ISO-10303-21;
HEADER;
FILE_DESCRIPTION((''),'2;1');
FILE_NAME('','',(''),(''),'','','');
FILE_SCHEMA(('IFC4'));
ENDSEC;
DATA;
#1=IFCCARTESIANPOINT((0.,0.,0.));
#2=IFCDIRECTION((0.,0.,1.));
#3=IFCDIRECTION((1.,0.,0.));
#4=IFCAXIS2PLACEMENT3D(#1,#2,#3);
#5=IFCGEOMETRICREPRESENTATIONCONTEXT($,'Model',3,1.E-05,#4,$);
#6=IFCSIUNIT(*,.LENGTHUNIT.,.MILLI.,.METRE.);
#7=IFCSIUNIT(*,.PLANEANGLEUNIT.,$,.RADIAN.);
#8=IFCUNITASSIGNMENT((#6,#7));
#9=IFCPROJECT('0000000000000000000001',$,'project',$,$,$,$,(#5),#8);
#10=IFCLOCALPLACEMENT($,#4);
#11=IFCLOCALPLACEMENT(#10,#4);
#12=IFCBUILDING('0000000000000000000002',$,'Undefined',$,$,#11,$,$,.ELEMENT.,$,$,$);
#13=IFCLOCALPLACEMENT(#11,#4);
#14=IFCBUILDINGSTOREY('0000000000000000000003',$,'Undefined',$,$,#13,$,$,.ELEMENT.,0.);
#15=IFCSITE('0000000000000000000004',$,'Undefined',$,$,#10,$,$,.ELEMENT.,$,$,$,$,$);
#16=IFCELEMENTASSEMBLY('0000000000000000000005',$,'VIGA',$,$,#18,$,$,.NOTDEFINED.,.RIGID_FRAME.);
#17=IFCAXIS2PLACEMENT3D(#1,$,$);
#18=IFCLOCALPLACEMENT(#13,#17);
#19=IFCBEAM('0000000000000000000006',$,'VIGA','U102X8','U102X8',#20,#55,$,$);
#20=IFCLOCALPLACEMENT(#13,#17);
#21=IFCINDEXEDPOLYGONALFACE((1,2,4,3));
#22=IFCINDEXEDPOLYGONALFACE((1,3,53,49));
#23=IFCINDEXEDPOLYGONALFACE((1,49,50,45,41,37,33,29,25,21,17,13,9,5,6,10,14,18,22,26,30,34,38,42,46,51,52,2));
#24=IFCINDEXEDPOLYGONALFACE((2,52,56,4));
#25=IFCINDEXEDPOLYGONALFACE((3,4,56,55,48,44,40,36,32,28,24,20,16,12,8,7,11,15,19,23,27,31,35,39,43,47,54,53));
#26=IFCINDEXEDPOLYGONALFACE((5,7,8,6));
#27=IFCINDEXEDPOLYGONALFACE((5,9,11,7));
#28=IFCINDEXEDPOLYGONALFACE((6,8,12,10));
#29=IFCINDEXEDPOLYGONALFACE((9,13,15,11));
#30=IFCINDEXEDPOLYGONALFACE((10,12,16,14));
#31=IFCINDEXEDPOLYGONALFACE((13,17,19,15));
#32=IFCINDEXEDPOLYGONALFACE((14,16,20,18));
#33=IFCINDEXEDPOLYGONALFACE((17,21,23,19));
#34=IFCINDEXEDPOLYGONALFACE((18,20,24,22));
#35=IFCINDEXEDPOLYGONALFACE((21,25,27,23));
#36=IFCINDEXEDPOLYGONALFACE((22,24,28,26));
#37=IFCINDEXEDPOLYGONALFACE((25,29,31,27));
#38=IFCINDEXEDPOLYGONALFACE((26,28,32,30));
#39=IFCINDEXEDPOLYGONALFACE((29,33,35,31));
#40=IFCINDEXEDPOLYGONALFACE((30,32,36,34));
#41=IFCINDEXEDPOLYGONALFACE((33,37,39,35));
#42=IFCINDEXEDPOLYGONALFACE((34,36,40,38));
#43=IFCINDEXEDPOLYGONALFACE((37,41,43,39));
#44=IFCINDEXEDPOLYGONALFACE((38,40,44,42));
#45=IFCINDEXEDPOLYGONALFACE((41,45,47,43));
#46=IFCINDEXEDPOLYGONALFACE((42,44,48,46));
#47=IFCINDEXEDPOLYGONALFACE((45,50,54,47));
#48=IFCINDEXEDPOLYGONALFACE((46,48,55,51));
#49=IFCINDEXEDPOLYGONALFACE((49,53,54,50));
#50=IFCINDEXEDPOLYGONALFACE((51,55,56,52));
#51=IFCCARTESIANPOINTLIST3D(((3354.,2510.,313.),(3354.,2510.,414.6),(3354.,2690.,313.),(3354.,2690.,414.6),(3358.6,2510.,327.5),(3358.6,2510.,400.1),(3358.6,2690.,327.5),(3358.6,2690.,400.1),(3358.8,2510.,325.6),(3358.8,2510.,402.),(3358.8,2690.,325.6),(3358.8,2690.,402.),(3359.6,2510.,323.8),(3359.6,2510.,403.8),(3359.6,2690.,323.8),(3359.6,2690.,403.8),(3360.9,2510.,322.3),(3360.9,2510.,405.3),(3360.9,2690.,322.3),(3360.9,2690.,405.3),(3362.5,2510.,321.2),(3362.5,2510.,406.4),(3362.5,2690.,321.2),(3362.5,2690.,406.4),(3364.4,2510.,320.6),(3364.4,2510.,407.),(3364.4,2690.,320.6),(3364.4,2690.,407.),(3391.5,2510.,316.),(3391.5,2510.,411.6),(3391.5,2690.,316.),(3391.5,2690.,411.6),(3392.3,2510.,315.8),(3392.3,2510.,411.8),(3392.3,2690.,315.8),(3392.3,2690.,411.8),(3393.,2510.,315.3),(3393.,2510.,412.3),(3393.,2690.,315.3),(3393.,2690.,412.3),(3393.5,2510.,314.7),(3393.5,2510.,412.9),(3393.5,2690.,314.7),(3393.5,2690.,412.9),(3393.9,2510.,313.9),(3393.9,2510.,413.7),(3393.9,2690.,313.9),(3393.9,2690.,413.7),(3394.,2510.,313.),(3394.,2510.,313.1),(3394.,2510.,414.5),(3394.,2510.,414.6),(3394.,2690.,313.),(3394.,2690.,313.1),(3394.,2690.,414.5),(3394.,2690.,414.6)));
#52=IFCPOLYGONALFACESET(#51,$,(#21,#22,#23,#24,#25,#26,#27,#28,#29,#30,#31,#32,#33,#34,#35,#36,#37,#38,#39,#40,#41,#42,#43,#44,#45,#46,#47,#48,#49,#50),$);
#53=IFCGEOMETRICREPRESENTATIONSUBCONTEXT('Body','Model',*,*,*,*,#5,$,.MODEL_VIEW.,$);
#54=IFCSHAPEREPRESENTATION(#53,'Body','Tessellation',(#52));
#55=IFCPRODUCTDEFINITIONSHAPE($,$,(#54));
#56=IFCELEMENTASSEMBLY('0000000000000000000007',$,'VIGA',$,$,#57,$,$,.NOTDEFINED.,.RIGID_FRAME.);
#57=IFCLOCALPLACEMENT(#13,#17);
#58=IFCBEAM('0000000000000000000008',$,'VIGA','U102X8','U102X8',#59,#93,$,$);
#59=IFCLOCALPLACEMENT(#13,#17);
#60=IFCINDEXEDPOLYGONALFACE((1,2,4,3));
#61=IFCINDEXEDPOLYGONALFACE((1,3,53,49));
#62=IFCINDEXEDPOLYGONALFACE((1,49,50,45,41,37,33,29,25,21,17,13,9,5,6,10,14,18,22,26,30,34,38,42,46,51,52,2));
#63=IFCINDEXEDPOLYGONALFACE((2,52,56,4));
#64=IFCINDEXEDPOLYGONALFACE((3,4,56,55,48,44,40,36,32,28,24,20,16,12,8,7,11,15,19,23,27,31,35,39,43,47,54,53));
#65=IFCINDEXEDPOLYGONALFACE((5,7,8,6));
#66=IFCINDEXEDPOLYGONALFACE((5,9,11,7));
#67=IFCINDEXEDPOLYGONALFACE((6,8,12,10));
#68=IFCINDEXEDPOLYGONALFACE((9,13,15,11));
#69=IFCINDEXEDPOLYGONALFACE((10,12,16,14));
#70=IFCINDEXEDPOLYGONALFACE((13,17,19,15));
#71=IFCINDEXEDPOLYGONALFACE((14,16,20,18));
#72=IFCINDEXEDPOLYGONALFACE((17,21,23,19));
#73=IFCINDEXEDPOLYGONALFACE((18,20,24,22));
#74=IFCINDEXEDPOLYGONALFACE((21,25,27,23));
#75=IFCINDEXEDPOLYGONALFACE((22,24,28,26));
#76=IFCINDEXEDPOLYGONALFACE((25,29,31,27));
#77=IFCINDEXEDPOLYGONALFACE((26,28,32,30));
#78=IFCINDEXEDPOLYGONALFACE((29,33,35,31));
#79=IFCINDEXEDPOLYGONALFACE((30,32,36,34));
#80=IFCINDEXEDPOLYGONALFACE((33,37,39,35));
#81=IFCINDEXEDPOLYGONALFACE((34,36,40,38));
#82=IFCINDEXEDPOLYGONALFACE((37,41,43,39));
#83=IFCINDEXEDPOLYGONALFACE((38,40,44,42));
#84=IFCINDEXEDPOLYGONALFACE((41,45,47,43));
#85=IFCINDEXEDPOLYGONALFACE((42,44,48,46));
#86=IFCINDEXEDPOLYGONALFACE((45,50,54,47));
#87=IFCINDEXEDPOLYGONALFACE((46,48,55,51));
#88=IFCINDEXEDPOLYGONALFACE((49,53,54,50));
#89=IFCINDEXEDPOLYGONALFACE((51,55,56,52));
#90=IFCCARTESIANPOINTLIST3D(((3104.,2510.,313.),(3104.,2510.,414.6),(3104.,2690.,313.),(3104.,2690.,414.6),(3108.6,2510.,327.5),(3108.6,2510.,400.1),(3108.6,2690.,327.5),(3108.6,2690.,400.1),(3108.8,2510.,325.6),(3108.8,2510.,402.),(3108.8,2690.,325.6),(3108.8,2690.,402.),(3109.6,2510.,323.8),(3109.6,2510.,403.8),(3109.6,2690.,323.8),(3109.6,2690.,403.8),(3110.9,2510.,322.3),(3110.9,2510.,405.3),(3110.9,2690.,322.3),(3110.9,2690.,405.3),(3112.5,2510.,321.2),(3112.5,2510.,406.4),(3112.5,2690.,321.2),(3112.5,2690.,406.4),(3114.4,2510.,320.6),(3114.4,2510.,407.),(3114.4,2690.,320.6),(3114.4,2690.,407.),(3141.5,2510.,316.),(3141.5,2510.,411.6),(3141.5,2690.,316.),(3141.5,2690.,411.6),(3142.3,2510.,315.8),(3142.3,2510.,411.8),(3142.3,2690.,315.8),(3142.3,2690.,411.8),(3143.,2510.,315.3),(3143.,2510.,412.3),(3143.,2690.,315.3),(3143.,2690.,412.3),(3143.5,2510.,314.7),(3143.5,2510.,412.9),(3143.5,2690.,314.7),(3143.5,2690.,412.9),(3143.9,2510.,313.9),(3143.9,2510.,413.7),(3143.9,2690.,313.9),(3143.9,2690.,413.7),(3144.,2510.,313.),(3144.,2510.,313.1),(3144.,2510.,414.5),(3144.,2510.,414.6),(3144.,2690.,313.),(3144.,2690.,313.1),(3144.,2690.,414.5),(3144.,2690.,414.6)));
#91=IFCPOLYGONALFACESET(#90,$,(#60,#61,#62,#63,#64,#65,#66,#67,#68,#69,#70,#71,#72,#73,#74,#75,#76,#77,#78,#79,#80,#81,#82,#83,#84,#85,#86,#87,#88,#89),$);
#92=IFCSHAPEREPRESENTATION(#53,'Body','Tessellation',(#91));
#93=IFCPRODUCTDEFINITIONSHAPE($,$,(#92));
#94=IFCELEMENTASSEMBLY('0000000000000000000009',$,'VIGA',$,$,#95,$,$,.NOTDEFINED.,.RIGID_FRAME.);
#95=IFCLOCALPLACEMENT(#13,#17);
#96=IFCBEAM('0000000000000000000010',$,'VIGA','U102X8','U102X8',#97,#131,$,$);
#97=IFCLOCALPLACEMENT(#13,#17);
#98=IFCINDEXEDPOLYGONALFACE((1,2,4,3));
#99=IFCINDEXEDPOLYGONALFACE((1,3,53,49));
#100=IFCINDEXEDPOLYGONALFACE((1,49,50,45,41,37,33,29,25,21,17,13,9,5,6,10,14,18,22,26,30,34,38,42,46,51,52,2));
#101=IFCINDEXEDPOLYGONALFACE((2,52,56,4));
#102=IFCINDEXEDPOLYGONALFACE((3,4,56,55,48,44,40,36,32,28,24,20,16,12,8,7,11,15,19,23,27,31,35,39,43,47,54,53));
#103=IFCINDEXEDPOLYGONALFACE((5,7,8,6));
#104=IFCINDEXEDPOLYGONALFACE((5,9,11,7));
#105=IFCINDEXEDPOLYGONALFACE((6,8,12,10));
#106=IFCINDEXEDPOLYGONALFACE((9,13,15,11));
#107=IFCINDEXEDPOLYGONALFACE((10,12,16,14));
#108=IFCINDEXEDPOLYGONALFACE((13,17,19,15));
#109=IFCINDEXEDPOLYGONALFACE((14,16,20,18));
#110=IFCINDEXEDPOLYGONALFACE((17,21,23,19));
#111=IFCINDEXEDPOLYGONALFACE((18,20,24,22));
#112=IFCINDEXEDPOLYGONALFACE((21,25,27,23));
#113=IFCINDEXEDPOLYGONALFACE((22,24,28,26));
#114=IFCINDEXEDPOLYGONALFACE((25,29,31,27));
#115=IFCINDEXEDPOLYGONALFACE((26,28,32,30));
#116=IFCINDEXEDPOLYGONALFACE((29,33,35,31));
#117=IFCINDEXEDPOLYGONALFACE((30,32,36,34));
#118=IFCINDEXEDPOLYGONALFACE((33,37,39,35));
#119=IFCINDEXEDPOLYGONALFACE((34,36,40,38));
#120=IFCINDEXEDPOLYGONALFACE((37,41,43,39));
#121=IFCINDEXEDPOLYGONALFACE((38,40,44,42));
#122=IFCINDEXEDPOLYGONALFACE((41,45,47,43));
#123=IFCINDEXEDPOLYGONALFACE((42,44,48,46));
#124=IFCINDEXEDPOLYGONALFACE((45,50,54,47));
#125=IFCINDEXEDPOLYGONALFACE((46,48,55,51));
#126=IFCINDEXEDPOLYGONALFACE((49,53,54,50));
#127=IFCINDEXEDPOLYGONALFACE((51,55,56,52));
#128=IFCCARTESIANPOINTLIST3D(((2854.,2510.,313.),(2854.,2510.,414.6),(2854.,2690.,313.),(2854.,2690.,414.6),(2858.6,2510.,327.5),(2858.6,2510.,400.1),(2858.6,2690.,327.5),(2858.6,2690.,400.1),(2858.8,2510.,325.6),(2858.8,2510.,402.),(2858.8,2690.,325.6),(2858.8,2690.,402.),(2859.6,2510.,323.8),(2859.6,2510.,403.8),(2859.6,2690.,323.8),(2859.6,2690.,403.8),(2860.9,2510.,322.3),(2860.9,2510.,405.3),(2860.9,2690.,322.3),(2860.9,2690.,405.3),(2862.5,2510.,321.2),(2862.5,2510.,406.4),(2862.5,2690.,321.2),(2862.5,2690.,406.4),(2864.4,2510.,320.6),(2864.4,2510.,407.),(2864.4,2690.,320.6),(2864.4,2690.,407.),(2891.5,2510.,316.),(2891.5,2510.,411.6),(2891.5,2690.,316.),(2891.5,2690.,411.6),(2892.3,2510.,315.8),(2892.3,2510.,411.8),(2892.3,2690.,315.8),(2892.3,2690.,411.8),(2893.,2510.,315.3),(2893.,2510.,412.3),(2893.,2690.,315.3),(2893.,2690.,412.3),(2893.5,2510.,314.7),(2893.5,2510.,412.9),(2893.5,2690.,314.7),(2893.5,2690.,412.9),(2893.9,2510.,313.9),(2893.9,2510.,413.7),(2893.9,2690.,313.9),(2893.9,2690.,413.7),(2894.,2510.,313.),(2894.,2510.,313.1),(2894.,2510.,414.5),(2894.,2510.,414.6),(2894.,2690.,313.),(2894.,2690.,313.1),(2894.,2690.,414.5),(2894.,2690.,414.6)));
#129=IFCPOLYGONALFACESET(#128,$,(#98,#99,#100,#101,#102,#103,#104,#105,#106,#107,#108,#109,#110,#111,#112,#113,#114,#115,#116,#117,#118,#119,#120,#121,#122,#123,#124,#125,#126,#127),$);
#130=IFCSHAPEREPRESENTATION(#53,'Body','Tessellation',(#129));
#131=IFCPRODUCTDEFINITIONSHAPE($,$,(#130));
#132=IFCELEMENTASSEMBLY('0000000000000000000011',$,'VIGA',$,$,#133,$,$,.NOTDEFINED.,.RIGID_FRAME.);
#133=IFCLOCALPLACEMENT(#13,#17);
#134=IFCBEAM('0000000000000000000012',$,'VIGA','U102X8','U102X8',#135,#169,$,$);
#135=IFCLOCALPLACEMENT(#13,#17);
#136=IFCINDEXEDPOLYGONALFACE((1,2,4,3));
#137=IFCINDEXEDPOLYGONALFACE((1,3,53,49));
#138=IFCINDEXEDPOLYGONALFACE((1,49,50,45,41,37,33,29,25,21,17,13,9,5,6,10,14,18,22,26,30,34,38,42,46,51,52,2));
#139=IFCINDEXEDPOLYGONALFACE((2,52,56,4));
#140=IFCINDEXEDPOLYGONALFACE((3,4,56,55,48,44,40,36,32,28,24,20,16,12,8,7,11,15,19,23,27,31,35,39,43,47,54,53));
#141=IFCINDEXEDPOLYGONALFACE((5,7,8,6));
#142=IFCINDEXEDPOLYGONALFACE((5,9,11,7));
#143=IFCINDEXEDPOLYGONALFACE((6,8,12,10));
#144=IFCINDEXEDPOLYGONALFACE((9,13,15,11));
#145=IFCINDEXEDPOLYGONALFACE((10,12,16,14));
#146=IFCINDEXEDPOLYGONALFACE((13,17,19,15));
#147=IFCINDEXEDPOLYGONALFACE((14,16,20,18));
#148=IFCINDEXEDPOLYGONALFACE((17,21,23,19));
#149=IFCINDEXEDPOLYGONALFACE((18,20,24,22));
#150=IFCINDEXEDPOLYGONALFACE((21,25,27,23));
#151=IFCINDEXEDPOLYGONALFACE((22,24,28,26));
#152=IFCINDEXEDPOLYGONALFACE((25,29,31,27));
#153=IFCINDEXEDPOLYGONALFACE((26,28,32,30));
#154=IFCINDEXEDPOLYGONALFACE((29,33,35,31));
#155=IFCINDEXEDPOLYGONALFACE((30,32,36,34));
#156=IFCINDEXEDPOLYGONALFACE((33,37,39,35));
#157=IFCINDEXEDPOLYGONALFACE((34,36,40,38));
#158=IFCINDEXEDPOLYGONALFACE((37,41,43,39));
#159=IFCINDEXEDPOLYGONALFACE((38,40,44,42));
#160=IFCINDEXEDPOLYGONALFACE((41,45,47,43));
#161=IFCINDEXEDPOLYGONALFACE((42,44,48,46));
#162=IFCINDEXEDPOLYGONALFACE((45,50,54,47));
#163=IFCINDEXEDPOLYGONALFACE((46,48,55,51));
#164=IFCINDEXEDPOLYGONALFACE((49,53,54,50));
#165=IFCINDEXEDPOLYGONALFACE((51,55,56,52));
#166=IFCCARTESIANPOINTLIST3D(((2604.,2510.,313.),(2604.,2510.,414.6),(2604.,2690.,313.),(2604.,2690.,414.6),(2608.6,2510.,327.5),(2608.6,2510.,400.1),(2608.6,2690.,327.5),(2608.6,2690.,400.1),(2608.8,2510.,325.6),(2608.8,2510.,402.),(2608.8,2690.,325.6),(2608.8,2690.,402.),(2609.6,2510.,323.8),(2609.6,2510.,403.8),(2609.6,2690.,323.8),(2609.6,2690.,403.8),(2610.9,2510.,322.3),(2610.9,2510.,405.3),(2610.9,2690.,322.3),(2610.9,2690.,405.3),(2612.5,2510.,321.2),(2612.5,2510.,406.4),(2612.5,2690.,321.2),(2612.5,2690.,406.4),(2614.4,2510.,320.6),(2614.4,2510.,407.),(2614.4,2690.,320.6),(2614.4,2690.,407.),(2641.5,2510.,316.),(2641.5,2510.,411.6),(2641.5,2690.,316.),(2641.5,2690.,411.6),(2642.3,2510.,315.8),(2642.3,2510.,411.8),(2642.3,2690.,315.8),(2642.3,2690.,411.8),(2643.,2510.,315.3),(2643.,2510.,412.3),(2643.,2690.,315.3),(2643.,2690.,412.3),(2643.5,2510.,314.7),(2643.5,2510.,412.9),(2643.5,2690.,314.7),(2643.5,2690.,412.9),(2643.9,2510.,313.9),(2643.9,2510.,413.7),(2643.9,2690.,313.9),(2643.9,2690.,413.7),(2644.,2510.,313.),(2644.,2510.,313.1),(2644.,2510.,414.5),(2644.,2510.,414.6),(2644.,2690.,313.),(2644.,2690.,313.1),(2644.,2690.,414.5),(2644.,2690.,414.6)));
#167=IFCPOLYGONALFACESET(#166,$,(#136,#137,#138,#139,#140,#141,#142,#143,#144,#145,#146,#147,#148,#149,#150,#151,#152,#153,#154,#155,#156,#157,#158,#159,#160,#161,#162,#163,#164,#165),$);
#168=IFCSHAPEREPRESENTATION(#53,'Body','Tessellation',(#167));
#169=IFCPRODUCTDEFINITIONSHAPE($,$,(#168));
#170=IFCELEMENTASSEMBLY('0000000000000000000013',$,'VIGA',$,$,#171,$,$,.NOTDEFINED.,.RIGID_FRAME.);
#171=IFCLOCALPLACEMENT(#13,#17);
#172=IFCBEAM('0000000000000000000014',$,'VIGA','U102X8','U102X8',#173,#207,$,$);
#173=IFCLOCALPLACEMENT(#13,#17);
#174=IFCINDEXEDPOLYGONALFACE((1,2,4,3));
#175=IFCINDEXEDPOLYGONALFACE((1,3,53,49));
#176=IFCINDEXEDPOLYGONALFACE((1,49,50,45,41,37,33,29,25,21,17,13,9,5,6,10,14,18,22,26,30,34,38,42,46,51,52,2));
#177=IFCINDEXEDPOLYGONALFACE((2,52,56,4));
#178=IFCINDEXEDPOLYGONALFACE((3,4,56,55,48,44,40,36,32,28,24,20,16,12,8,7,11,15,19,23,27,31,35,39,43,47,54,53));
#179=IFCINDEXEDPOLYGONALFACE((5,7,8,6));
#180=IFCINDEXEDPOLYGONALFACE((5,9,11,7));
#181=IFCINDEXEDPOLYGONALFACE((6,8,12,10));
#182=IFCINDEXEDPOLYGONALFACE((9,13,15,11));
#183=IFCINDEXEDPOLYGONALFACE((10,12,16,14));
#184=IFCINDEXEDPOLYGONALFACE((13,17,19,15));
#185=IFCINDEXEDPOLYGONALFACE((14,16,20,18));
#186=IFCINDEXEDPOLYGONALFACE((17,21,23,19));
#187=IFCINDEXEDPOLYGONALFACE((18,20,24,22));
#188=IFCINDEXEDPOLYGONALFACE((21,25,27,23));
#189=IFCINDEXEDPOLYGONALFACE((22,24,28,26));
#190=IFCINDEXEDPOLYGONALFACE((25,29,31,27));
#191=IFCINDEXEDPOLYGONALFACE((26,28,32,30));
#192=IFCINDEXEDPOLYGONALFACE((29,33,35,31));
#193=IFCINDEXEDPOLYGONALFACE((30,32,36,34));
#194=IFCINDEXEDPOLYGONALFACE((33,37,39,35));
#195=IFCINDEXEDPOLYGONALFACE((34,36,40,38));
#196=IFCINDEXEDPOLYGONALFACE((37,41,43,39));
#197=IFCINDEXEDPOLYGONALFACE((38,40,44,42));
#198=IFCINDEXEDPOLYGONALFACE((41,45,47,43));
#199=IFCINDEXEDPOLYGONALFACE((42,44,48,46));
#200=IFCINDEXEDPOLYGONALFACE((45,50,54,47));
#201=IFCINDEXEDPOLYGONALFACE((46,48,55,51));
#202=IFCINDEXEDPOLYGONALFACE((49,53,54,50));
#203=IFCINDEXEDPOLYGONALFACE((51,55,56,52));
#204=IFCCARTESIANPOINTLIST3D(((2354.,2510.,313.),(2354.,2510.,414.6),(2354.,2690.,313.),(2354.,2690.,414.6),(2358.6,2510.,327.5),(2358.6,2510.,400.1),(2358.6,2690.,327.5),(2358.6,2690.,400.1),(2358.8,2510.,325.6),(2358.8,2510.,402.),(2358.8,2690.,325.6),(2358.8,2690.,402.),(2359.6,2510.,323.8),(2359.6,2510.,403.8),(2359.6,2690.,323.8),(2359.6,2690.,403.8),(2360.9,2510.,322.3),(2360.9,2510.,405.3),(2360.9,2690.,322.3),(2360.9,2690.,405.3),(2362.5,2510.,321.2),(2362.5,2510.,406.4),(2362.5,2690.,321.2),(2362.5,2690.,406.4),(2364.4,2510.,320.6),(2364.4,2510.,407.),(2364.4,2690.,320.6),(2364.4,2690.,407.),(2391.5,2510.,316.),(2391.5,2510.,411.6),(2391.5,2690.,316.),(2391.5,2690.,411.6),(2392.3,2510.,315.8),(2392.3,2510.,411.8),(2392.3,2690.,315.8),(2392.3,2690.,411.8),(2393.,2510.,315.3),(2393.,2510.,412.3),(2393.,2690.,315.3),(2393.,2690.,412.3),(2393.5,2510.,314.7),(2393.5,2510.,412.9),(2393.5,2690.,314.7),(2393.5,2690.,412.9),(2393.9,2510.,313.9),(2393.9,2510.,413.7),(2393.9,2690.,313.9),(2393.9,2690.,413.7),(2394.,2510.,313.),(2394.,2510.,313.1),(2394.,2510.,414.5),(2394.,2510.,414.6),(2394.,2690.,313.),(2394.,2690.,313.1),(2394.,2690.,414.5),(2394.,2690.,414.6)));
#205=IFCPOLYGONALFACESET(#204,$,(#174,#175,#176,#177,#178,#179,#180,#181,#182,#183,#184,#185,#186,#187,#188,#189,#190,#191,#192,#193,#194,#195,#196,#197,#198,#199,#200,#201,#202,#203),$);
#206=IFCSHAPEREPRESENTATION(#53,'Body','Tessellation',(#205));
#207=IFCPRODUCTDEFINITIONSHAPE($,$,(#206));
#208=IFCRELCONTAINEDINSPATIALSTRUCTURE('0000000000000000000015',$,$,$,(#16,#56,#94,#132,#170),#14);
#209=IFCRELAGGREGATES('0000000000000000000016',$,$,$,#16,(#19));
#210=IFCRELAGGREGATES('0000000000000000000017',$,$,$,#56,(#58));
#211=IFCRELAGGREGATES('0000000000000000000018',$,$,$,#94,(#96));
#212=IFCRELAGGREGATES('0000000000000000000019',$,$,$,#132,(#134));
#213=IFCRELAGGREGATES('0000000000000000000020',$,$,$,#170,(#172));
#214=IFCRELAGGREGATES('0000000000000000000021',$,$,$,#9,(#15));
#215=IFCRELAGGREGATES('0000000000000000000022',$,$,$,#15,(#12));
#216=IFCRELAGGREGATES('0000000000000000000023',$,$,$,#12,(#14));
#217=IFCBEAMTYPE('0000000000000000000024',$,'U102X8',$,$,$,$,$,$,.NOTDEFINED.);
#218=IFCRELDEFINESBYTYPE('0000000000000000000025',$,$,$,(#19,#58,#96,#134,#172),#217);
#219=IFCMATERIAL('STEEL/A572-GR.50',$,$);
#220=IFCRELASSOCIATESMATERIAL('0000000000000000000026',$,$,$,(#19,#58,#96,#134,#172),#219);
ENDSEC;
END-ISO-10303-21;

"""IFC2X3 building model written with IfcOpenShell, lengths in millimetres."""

from ifc_helpers import new_model, si_unit, frame, origin_with_axes, origin_2d_with_axis, place, context, subcontext, project, spatial, u_section, extrude, material, type_object, element, aggregate, save


model = new_model("IFC2X3")

# Units and contexts
model_context = context("Model", 3, precision=1e-05, world=origin_with_axes())
body_context = subcontext(model_context, "Body", "Model", "MODEL_VIEW")
ifc_project = project(units=[si_unit("LENGTHUNIT", "METRE", prefix="MILLI"), si_unit("PLANEANGLEUNIT", "RADIAN")], contexts=[model_context])

# Site, building, storey
site_placement = place(None, origin_with_axes())
site = spatial("IfcSite", under=ifc_project, at=site_placement, Name="Undefined", CompositionType="ELEMENT")
building_placement = place(site_placement, origin_with_axes())
building = spatial("IfcBuilding", under=site, at=building_placement, Name="Undefined", CompositionType="ELEMENT")
storey_placement = place(building_placement, origin_with_axes())
storey = spatial("IfcBuildingStorey", under=building, at=storey_placement, Name="Undefined", CompositionType="ELEMENT", Elevation=0.0)

# Element assemblies, beams
assembly_1_placement = place(storey_placement, origin_with_axes())
assembly_1 = element("IfcElementAssembly", 1, at=assembly_1_placement, inside=storey, Name="VIGA", AssemblyPlace="NOTDEFINED", PredefinedType="RIGID_FRAME")
ifc_material_1 = material(Name="STEEL/A572-GR.50")
beam_type_1 = type_object("IfcBeamType", Name="U102X8", PredefinedType="NOTDEFINED")
beam_1_placement = place(assembly_1_placement, frame((3374.0, 2510.0, 363.8), z_axis=(0.0, 0.0, 1.0), x_axis=(0.0, 1.0, 0.0)))
beam_1 = element("IfcBeam", 2, at=beam_1_placement, type_object=beam_type_1, material=ifc_material_1, Name="VIGA", Description="U102X8", ObjectType="U102X8", context=body_context, shape_type="SweptSolid", body=[
    extrude(u_section(Depth=101.6, FlangeWidth=40.0, WebThickness=4.6, FlangeThickness=6.0, FilletRadius=7.0, EdgeRadius=3.0, FlangeSlope=0.16839, at=origin_2d_with_axis()), frame((180.0, 0.0, 0.0), z_axis=(-1.0, 0.0, 0.0), x_axis=(0.0, -1.0, 0.0)), (0.0, 0.0, 1.0), 180.0),
])
aggregate(assembly_1, [beam_1])
assembly_2_placement = place(storey_placement, origin_with_axes())
assembly_2 = element("IfcElementAssembly", 3, at=assembly_2_placement, inside=storey, Name="VIGA", AssemblyPlace="NOTDEFINED", PredefinedType="RIGID_FRAME")
beam_2_placement = place(assembly_2_placement, frame((3124.0, 2510.0, 363.8), z_axis=(0.0, 0.0, 1.0), x_axis=(0.0, 1.0, 0.0)))
beam_2 = element("IfcBeam", 4, at=beam_2_placement, type_object=beam_type_1, material=ifc_material_1, Name="VIGA", Description="U102X8", ObjectType="U102X8", context=body_context, shape_type="SweptSolid", body=[
    extrude(u_section(Depth=101.6, FlangeWidth=40.0, WebThickness=4.6, FlangeThickness=6.0, FilletRadius=7.0, EdgeRadius=3.0, FlangeSlope=0.16839, at=origin_2d_with_axis()), frame((180.0, 0.0, 0.0), z_axis=(-1.0, 0.0, 0.0), x_axis=(0.0, -1.0, 0.0)), (0.0, 0.0, 1.0), 180.0),
])
aggregate(assembly_2, [beam_2])
assembly_3_placement = place(storey_placement, origin_with_axes())
assembly_3 = element("IfcElementAssembly", 5, at=assembly_3_placement, inside=storey, Name="VIGA", AssemblyPlace="NOTDEFINED", PredefinedType="RIGID_FRAME")
beam_3_placement = place(assembly_3_placement, frame((2874.0, 2510.0, 363.8), z_axis=(0.0, 0.0, 1.0), x_axis=(0.0, 1.0, 0.0)))
beam_3 = element("IfcBeam", 6, at=beam_3_placement, type_object=beam_type_1, material=ifc_material_1, Name="VIGA", Description="U102X8", ObjectType="U102X8", context=body_context, shape_type="SweptSolid", body=[
    extrude(u_section(Depth=101.6, FlangeWidth=40.0, WebThickness=4.6, FlangeThickness=6.0, FilletRadius=7.0, EdgeRadius=3.0, FlangeSlope=0.16839, at=origin_2d_with_axis()), frame((180.0, 0.0, 0.0), z_axis=(-1.0, 0.0, 0.0), x_axis=(0.0, -1.0, 0.0)), (0.0, 0.0, 1.0), 180.0),
])
aggregate(assembly_3, [beam_3])
assembly_4_placement = place(storey_placement, origin_with_axes())
assembly_4 = element("IfcElementAssembly", 7, at=assembly_4_placement, inside=storey, Name="VIGA", AssemblyPlace="NOTDEFINED", PredefinedType="RIGID_FRAME")
beam_4_placement = place(assembly_4_placement, frame((2624.0, 2510.0, 363.8), z_axis=(0.0, 0.0, 1.0), x_axis=(0.0, 1.0, 0.0)))
beam_4 = element("IfcBeam", 8, at=beam_4_placement, type_object=beam_type_1, material=ifc_material_1, Name="VIGA", Description="U102X8", ObjectType="U102X8", context=body_context, shape_type="SweptSolid", body=[
    extrude(u_section(Depth=101.6, FlangeWidth=40.0, WebThickness=4.6, FlangeThickness=6.0, FilletRadius=7.0, EdgeRadius=3.0, FlangeSlope=0.16839, at=origin_2d_with_axis()), frame((180.0, 0.0, 0.0), z_axis=(-1.0, 0.0, 0.0), x_axis=(0.0, -1.0, 0.0)), (0.0, 0.0, 1.0), 180.0),
])
aggregate(assembly_4, [beam_4])
assembly_5_placement = place(storey_placement, origin_with_axes())
assembly_5 = element("IfcElementAssembly", 9, at=assembly_5_placement, inside=storey, Name="VIGA", AssemblyPlace="NOTDEFINED", PredefinedType="RIGID_FRAME")
beam_5_placement = place(assembly_5_placement, frame((2374.0, 2510.0, 363.8), z_axis=(0.0, 0.0, 1.0), x_axis=(0.0, 1.0, 0.0)))
beam_5 = element("IfcBeam", 10, at=beam_5_placement, type_object=beam_type_1, material=ifc_material_1, Name="VIGA", Description="U102X8", ObjectType="U102X8", context=body_context, shape_type="SweptSolid", body=[
    extrude(u_section(Depth=101.6, FlangeWidth=40.0, WebThickness=4.6, FlangeThickness=6.0, FilletRadius=7.0, EdgeRadius=3.0, FlangeSlope=0.16839, at=origin_2d_with_axis()), frame((180.0, 0.0, 0.0), z_axis=(-1.0, 0.0, 0.0), x_axis=(0.0, -1.0, 0.0)), (0.0, 0.0, 1.0), 180.0),
])
aggregate(assembly_5, [beam_5])

save(model, "model.ifc")
